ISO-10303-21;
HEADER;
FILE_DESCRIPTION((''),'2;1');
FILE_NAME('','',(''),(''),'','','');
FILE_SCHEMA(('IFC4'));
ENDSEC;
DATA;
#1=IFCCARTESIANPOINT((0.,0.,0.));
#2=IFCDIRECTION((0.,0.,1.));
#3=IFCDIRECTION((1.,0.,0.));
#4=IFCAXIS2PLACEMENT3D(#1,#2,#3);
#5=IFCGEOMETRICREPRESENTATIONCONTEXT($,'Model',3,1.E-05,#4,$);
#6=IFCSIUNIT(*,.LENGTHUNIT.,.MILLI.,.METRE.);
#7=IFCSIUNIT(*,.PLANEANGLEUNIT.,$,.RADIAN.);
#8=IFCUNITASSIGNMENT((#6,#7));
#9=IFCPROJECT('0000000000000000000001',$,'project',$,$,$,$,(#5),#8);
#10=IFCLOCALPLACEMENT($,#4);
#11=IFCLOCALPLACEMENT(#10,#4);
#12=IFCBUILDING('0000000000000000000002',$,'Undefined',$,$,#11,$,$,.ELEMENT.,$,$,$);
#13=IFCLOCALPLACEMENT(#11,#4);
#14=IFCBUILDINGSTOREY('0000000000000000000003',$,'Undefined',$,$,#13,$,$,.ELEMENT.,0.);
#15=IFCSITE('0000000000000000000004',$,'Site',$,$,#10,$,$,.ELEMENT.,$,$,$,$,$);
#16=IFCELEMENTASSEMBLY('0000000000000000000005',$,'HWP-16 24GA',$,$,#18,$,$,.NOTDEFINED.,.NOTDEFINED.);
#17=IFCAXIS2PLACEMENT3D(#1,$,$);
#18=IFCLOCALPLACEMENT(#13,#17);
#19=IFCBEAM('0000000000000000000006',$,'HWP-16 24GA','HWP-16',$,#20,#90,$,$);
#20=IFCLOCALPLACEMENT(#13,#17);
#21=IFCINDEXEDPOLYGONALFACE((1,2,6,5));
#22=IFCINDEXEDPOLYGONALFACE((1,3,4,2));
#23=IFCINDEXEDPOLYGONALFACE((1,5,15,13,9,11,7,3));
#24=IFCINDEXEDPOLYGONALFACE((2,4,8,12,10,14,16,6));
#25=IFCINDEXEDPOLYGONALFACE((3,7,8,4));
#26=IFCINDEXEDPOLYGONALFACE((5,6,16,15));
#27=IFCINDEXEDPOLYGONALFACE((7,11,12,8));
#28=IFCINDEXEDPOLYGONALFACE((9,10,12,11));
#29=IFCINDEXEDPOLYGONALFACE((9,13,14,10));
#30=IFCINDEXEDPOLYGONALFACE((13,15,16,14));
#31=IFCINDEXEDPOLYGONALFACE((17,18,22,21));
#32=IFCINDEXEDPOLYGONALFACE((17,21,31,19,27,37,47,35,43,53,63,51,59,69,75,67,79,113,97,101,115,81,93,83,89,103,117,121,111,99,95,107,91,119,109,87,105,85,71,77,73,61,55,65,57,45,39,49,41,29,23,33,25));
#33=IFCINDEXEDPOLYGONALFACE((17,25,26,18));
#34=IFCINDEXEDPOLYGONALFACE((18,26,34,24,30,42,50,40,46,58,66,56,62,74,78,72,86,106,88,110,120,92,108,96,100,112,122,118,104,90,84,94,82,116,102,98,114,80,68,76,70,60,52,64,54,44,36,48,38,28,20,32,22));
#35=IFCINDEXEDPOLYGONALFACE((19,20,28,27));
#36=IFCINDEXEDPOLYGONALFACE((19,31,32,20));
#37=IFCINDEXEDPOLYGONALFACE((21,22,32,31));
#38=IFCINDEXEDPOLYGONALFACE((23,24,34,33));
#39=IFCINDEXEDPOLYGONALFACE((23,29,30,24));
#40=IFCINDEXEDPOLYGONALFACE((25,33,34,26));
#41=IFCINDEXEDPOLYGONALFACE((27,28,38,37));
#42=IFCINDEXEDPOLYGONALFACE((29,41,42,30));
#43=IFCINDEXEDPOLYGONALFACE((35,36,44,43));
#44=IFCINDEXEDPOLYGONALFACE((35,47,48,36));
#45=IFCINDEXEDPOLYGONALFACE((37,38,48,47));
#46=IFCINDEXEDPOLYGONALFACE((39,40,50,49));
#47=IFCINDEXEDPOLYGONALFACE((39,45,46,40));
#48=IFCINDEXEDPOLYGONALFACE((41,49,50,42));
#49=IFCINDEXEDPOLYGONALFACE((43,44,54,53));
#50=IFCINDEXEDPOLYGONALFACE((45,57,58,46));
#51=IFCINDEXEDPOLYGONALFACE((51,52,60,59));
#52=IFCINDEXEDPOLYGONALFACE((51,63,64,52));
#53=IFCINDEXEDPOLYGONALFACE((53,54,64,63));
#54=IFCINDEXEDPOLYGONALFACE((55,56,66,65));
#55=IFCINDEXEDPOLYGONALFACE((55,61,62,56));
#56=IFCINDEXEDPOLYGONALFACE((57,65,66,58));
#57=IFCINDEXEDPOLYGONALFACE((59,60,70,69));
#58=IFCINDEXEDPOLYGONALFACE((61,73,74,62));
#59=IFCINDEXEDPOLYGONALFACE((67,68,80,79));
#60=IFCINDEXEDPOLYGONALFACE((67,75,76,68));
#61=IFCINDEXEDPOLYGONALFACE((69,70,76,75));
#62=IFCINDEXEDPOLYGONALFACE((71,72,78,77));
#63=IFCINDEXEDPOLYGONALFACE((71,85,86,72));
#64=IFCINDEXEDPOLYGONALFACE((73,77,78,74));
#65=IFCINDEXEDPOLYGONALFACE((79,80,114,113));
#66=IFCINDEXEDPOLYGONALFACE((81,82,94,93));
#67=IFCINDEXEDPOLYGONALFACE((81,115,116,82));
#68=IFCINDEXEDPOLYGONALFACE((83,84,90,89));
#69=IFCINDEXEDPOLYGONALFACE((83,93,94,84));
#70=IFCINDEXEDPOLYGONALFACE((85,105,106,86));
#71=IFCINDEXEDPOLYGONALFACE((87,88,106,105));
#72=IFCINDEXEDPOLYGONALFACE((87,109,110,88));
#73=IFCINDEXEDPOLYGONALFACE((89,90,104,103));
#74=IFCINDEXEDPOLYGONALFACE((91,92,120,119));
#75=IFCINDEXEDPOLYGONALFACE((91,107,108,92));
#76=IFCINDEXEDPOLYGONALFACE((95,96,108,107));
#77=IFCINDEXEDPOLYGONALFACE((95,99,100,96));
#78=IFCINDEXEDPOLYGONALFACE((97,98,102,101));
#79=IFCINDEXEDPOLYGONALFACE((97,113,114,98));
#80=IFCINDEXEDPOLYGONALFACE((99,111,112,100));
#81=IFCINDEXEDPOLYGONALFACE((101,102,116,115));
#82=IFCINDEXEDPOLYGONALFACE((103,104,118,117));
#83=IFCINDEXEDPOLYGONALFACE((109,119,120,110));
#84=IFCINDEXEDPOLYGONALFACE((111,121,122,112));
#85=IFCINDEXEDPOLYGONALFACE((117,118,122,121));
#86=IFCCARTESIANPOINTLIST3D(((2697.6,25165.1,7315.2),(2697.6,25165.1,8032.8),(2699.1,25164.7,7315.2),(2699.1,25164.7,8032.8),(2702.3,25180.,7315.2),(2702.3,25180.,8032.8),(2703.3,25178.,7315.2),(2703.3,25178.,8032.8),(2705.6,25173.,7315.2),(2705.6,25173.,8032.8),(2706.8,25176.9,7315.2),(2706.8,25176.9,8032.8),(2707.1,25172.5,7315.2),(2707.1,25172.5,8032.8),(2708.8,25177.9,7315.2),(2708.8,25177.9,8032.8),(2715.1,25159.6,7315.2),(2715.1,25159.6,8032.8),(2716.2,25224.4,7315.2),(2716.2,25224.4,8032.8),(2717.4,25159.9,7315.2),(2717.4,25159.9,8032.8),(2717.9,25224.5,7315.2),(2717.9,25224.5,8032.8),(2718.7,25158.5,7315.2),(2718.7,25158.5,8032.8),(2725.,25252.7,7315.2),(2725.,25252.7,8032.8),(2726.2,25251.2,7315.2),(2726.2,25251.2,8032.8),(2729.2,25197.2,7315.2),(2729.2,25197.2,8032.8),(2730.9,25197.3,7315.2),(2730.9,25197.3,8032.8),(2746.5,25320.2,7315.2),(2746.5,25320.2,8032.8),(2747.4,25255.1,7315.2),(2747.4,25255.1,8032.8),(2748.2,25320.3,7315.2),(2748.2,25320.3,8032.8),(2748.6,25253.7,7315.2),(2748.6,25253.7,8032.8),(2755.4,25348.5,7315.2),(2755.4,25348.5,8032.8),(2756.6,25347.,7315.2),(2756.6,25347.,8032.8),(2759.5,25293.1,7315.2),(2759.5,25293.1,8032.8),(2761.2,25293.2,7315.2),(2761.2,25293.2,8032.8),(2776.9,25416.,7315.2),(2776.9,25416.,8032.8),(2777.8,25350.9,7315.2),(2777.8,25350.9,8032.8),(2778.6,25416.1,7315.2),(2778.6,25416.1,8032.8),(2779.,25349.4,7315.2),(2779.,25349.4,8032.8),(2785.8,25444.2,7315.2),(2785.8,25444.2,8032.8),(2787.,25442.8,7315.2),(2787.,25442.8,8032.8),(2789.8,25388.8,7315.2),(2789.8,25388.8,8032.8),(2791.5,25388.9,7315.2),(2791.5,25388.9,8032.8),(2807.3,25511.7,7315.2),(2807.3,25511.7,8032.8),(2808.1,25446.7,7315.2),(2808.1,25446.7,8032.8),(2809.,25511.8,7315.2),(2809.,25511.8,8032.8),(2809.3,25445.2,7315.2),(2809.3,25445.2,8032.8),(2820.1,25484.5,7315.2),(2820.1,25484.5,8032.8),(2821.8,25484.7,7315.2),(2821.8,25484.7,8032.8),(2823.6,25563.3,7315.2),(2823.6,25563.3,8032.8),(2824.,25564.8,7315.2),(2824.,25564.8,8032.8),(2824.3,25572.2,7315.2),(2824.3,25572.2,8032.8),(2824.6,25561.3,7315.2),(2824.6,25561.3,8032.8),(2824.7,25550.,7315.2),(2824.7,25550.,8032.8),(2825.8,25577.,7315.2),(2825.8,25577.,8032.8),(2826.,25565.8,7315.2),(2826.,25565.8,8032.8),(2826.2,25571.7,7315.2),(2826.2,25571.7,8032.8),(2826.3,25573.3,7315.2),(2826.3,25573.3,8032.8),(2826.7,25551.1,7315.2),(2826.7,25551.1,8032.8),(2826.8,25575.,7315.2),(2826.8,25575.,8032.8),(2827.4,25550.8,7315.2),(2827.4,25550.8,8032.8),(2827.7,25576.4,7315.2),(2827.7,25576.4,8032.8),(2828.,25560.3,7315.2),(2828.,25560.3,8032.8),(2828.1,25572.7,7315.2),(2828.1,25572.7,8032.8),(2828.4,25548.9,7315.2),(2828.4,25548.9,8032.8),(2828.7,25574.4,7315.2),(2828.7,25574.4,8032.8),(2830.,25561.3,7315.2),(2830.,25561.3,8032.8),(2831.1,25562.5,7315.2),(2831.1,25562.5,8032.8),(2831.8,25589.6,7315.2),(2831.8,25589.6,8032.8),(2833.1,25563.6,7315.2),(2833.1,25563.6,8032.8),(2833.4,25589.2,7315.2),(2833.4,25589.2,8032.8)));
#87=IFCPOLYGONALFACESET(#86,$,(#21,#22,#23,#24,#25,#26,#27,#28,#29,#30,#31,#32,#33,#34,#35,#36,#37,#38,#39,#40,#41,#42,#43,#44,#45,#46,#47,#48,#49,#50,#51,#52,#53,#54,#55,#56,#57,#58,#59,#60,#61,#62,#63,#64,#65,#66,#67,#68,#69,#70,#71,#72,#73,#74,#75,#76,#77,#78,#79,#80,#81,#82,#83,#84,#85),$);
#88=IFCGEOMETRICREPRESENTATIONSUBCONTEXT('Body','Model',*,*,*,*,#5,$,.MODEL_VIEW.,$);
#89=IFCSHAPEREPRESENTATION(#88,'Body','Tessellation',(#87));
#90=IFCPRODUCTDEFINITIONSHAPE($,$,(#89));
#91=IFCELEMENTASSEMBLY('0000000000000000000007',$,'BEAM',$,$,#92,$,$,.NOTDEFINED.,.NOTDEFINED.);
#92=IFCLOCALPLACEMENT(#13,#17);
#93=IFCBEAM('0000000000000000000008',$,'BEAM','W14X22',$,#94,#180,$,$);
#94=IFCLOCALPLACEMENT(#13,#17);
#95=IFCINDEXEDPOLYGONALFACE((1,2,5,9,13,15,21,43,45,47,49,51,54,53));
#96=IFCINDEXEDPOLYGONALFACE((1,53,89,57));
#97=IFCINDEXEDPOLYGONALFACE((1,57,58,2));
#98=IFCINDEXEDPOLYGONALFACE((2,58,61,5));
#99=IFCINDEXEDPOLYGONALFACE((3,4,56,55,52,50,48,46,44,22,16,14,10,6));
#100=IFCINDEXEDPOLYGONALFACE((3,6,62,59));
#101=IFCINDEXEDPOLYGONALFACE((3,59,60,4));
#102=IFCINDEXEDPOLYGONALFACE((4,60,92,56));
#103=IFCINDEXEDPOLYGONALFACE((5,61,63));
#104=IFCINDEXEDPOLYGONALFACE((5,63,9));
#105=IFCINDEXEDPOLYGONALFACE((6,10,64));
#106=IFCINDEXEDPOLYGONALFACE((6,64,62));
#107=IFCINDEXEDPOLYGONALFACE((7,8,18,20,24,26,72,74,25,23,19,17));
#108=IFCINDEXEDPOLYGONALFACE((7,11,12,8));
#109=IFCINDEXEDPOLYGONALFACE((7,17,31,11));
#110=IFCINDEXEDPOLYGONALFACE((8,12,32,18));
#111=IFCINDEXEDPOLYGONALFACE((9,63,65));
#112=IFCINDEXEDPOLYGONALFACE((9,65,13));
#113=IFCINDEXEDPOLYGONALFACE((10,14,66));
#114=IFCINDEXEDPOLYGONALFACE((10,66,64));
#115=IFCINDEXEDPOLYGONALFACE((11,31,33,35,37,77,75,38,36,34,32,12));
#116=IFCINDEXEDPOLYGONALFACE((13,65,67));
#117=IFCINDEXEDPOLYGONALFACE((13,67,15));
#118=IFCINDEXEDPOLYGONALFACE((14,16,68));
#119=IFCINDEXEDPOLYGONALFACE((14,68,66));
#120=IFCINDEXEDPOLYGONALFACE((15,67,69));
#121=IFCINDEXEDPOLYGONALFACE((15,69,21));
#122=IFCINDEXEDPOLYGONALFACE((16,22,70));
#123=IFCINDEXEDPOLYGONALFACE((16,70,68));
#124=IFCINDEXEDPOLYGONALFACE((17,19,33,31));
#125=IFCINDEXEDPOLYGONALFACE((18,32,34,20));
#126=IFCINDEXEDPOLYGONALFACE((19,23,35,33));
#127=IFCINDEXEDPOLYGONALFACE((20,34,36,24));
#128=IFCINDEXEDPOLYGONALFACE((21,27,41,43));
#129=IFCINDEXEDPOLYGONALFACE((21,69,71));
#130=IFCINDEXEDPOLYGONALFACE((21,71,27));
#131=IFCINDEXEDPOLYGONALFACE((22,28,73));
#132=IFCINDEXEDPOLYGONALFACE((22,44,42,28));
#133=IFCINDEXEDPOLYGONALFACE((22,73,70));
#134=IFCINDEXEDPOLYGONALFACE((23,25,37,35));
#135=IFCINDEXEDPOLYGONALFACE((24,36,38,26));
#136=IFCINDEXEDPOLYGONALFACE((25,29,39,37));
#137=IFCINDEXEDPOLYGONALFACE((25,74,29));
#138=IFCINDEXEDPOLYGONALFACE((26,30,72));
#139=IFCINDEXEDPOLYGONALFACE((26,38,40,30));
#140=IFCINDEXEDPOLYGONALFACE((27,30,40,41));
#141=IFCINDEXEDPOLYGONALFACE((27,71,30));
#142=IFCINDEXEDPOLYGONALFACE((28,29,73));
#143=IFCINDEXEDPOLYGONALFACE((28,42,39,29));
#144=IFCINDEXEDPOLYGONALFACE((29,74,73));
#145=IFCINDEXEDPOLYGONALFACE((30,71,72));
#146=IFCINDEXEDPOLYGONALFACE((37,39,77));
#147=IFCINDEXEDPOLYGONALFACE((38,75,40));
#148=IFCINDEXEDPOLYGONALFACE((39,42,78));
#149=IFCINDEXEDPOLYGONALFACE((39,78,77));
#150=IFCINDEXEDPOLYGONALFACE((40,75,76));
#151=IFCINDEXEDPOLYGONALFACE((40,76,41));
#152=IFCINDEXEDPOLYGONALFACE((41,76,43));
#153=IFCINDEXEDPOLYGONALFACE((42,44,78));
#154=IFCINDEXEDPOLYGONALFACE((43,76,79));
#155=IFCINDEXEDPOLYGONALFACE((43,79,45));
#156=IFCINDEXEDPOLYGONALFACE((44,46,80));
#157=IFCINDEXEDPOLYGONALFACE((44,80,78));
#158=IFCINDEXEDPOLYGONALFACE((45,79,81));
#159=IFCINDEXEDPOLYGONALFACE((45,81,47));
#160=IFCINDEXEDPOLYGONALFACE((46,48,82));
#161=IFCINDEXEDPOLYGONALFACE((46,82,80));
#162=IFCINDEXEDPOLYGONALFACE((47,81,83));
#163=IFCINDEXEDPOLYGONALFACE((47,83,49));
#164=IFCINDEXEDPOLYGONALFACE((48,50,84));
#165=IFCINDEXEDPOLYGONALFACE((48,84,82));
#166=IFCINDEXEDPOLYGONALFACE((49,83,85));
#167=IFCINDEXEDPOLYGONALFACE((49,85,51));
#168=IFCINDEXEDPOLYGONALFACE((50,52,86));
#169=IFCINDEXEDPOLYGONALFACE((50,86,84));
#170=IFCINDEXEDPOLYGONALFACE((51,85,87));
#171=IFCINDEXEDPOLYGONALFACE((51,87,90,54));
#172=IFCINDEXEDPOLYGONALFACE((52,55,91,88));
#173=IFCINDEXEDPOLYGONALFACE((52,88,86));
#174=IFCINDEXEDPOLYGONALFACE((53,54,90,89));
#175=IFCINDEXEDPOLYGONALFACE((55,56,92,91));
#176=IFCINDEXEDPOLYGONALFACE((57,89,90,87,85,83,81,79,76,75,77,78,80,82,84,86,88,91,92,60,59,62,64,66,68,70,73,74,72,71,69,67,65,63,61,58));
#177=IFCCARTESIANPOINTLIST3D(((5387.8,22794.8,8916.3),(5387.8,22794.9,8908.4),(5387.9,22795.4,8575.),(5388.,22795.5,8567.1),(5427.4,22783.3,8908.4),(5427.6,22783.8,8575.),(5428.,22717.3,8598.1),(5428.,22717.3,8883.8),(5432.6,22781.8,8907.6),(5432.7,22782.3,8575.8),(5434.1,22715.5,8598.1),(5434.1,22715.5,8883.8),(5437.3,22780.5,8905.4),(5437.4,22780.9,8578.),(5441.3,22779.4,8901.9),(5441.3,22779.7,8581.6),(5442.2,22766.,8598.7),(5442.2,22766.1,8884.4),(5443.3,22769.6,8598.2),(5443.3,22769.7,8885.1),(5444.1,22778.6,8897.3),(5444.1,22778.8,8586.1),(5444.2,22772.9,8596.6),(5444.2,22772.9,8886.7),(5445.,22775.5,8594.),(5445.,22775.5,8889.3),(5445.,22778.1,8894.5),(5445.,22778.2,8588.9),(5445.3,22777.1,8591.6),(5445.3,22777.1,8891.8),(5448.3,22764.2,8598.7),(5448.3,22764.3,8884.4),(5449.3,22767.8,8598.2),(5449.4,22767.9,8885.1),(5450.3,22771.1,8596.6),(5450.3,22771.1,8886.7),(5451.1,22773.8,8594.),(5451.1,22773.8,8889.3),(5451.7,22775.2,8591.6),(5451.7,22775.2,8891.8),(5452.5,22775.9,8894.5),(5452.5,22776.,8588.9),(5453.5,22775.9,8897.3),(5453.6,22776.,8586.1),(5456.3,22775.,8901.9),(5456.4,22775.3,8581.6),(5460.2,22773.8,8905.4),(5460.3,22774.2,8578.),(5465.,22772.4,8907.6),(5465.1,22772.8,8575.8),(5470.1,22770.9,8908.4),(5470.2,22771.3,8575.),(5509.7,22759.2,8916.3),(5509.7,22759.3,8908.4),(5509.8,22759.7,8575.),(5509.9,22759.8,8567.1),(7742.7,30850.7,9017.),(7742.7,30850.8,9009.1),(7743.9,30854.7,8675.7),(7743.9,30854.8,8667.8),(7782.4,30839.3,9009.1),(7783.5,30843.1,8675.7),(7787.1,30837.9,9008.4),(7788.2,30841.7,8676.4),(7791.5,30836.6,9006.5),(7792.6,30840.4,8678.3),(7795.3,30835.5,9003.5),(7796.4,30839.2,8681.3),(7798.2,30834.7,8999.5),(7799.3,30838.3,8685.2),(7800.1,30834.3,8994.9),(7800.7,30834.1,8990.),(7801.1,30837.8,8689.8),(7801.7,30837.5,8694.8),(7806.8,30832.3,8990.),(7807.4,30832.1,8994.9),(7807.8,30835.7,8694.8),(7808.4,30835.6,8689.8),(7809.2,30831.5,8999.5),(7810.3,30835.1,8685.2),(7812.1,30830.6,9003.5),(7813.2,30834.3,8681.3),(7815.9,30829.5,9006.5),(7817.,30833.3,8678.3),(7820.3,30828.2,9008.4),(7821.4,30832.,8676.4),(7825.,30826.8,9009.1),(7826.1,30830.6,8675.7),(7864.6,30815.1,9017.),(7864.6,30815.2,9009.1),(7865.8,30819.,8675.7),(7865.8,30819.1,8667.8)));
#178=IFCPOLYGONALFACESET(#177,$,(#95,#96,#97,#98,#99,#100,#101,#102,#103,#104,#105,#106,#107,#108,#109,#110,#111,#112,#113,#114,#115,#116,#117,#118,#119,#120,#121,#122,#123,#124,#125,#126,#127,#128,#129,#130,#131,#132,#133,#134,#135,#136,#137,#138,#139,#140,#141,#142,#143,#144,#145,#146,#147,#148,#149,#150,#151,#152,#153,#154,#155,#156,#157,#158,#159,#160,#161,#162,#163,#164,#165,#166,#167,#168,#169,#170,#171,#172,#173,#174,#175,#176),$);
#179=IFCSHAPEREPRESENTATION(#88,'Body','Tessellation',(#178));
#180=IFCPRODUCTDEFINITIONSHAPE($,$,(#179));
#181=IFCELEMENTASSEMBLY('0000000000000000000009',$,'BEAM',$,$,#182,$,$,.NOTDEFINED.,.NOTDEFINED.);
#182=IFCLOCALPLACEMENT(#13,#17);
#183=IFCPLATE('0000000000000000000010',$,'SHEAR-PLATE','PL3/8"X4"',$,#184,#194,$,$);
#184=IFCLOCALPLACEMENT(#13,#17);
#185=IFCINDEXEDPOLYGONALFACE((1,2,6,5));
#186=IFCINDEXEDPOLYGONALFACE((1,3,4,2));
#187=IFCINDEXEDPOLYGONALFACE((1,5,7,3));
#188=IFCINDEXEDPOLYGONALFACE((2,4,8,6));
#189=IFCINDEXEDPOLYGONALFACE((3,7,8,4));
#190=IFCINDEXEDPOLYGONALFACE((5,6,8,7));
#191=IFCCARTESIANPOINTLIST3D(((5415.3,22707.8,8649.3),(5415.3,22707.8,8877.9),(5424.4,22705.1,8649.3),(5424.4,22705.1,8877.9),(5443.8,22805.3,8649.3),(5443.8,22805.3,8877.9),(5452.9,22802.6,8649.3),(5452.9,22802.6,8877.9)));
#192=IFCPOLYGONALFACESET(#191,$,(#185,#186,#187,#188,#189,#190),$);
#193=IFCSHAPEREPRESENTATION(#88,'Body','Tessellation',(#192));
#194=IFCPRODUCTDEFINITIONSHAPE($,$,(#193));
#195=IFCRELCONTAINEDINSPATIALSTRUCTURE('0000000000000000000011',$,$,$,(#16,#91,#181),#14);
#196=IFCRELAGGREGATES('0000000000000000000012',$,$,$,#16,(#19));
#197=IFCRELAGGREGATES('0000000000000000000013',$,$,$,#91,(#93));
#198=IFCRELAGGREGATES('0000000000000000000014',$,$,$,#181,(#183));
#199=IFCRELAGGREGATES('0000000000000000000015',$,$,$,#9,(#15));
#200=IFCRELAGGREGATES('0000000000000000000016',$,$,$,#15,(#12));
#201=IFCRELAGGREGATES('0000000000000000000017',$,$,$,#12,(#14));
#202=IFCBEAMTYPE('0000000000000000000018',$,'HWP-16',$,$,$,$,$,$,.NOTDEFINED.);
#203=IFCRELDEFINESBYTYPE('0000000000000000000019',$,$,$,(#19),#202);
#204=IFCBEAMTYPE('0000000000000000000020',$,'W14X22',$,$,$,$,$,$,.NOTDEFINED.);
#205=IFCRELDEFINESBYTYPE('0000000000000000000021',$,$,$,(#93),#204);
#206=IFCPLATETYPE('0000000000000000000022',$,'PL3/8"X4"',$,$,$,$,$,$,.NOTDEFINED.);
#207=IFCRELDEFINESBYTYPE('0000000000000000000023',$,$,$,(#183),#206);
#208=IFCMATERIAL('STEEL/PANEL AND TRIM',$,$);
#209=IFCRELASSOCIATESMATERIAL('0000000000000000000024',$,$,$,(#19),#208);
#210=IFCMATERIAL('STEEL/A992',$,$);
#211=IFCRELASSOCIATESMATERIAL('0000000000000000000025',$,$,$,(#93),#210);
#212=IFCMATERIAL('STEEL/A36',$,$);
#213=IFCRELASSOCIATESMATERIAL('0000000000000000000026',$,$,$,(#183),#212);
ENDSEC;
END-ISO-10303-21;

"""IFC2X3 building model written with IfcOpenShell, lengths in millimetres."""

from ifc_helpers import new_model, si_unit, frame, frame_2d, origin_with_axes, origin_2d_with_axis, place, context, subcontext, project, spatial, polyline, circle_curve, parameter, trimmed, segment, composite_curve, i_section, outline, extrude, boolean, clip, halfspace, material, type_object, element, aggregate, save


model = new_model("IFC2X3")

# Units and contexts
model_context = context("Model", 3, precision=1e-05, world=origin_with_axes())
body_context = subcontext(model_context, "Body", "Model", "MODEL_VIEW")
ifc_project = project(units=[si_unit("LENGTHUNIT", "METRE", prefix="MILLI"), si_unit("PLANEANGLEUNIT", "RADIAN")], contexts=[model_context])

# Site, building, storey
site_placement = place(None, origin_with_axes())
site = spatial("IfcSite", under=ifc_project, at=site_placement, Name="Site", CompositionType="ELEMENT")
building_placement = place(site_placement, origin_with_axes())
building = spatial("IfcBuilding", under=site, at=building_placement, Name="Undefined", CompositionType="ELEMENT")
storey_placement = place(building_placement, origin_with_axes())
storey = spatial("IfcBuildingStorey", under=building, at=storey_placement, Name="Undefined", CompositionType="ELEMENT", Elevation=0.0)

# Element assemblies, beams
ifc_material_1 = material(Name="STEEL/PANEL AND TRIM")
beam_type_1 = type_object("IfcBeamType", Name="HWP-16", PredefinedType="NOTDEFINED")
assembly_1_placement = place(storey_placement, origin_with_axes())
assembly_1 = element("IfcElementAssembly", 1, at=assembly_1_placement, inside=storey, Name="HWP-16 24GA", AssemblyPlace="NOTDEFINED", PredefinedType="NOTDEFINED")
beam_1_placement = place(assembly_1_placement, frame((2718.7, 25158.5, 8032.8), z_axis=(-0.953453, 0.301541, 0.0), x_axis=(0.0, 0.0, -1.0)))
beam_1 = element("IfcBeam", 2, at=beam_1_placement, type_object=beam_type_1, material=ifc_material_1, Name="HWP-16 24GA", Description="HWP-16", context=body_context, shape_type="Clipping", body=[
    clip(clip(extrude(outline(polyline([(40.7, 0.0), (0.0, 0.0), (-10.3, 22.1), (15.5, 22.1), (15.5, 15.2), (9.9, 15.2), (9.9, 16.8), (13.9, 16.8), (13.9, 20.5), (-7.8, 20.5), (1.0, 1.6), (40.1, 1.6), (62.1, 22.2), (91.7, 22.3), (100.8, 1.7), (140.6, 1.7), (162.6, 22.2), (192.2, 22.2), (201.3, 1.6), (241.0, 1.6), (263.1, 22.1), (292.7, 22.1), (301.8, 1.6), (341.5, 1.6), (363.5, 22.0), (417.6, 22.0), (417.6, 15.3), (406.9, 15.3), (406.9, 14.6), (419.2, 14.6), (419.2, 22.1), (426.4, 22.1), (426.4, 24.0), (431.3, 24.0), (431.3, 22.1), (445.2, 22.1), (445.2, 20.5), (429.7, 20.5), (429.7, 22.5), (427.9, 22.5), (427.9, 20.5), (420.7, 20.5), (420.7, 13.0), (405.3, 13.0), (405.3, 16.9), (416.0, 16.9), (416.0, 20.4), (364.1, 20.4), (342.1, 0.0), (300.7, 0.0), (291.6, 20.5), (263.7, 20.5), (241.6, 0.0), (200.3, 0.0), (191.2, 20.6), (163.2, 20.6), (141.3, 0.1), (99.8, 0.1), (90.7, 20.7), (62.7, 20.6), (40.7, 0.0)])), frame((10000.0, 0.0, 0.0), z_axis=(-1.0, 0.0, 0.0), x_axis=(0.0, -1.0, 0.0)), (0.0, 0.0, 1.0), 10000.0), halfspace(frame((10000.0, 0.0, -500.0), z_axis=(0.0, 1.0, 0.0), x_axis=(0.0, 0.0, 1.0)), False)), halfspace(frame((717.5, -500.0, -500.0), z_axis=(1.0, 0.0, 0.0), x_axis=(0.0, 0.0, 1.0)), False)),
])
aggregate(assembly_1, [beam_1])
assembly_2_placement = place(storey_placement, origin_with_axes())
assembly_2 = element("IfcElementAssembly", 3, at=assembly_2_placement, inside=storey, Name="BEAM", AssemblyPlace="NOTDEFINED", PredefinedType="NOTDEFINED")
ifc_material_2 = material(Name="STEEL/A992")
beam_type_2 = type_object("IfcBeamType", Name="W14X22", PredefinedType="NOTDEFINED")
beam_2_placement = place(assembly_2_placement, frame((5427.2, 22703.2, 8740.8), z_axis=(-0.003365, -0.01151, 0.999928), x_axis=(0.280559, 0.959762, 0.011992)))
beam_2 = element("IfcBeam", 4, at=beam_2_placement, type_object=beam_type_2, material=ifc_material_2, Name="BEAM", Description="W14X22", context=body_context, shape_type="CSG", body=[
    boolean("DIFFERENCE", boolean("DIFFERENCE", boolean("DIFFERENCE", extrude(i_section(OverallWidth=127.0, OverallDepth=349.2, WebThickness=6.3, FlangeThickness=7.9, FilletRadius=19.1, at=origin_2d_with_axis()), frame((8472.6, 0.0, 0.0), z_axis=(-1.0, 0.0, 0.0), x_axis=(0.0, -1.0, 0.0)), (0.0, 0.0, 1.0), 8512.9), extrude(outline(composite_curve([segment(polyline([(0.0, 0.0), (60.8, 0.0)]), True, "CONTINUOUS"), segment(trimmed(circle_curve(frame_2d((60.8, 12.7), x_axis=(0.0, -1.0)), 12.7), [parameter(0.0)], [parameter(1.570796)], True, "PARAMETER"), True, "CONTINUOUS"), segment(polyline([(73.5, 12.7), (73.5, 41.7), (0.5, 41.7), (0.0, 0.0)]), True, "CONTINUOUS")], self_intersect=True)), frame((5.4, 73.5, 142.9), z_axis=(0.0, -1.0, 0.0), x_axis=(1.0, 0.0, 0.0)), (0.0, 0.0, 1.0), 147.0)), extrude(outline(composite_curve([segment(polyline([(0.0, 0.0), (60.7, 0.0)]), True, "CONTINUOUS"), segment(trimmed(circle_curve(frame_2d((60.7, 12.7), x_axis=(0.0, -1.0)), 12.7), [parameter(0.0)], [parameter(1.570796)], True, "PARAMETER"), True, "CONTINUOUS"), segment(polyline([(73.4, 12.7), (73.4, 41.7), (-0.5, 41.7), (0.0, 0.0)]), True, "CONTINUOUS")], self_intersect=True)), frame((2.0, -73.5, -142.9), z_axis=(0.0, 1.0, 0.0), x_axis=(1.0, 0.0, 0.0)), (0.0, 0.0, 1.0), 147.0)), halfspace(frame((18.2, 0.0, 376.0), z_axis=(-0.999928, 0.0, 0.011992), x_axis=(0.0, -1.0, 0.0)), False)),
])
aggregate(assembly_2, [beam_2])

# Element assembly, plate
assembly_3_placement = place(storey_placement, origin_with_axes())
assembly_3 = element("IfcElementAssembly", 5, at=assembly_3_placement, inside=storey, Name="BEAM", AssemblyPlace="NOTDEFINED", PredefinedType="NOTDEFINED")
ifc_material_3 = material(Name="STEEL/A36")
plate_type = type_object("IfcPlateType", Name="PL3/8\"X4\"", PredefinedType="NOTDEFINED")
plate_1_placement = place(assembly_3_placement, frame((5419.8, 22706.4, 8877.9), z_axis=(0.959831, -0.280579, 0.0), x_axis=(0.0, 0.0, -1.0)))
plate_1 = element("IfcPlate", 6, at=plate_1_placement, type_object=plate_type, material=ifc_material_3, Name="SHEAR-PLATE", Description="PL3/8\"X4\"", context=body_context, shape_type="SweptSolid", body=[
    extrude(outline(polyline([(0.0, 0.0), (228.6, 0.0), (228.6, 101.6), (0.0, 101.6), (0.0, 0.0)])), frame((0.0, 0.0, -4.8), z_axis=(0.0, 0.0, 1.0), x_axis=(1.0, 0.0, 0.0)), (0.0, 0.0, 1.0), 9.5),
])
aggregate(assembly_3, [plate_1])

save(model, "model.ifc")
